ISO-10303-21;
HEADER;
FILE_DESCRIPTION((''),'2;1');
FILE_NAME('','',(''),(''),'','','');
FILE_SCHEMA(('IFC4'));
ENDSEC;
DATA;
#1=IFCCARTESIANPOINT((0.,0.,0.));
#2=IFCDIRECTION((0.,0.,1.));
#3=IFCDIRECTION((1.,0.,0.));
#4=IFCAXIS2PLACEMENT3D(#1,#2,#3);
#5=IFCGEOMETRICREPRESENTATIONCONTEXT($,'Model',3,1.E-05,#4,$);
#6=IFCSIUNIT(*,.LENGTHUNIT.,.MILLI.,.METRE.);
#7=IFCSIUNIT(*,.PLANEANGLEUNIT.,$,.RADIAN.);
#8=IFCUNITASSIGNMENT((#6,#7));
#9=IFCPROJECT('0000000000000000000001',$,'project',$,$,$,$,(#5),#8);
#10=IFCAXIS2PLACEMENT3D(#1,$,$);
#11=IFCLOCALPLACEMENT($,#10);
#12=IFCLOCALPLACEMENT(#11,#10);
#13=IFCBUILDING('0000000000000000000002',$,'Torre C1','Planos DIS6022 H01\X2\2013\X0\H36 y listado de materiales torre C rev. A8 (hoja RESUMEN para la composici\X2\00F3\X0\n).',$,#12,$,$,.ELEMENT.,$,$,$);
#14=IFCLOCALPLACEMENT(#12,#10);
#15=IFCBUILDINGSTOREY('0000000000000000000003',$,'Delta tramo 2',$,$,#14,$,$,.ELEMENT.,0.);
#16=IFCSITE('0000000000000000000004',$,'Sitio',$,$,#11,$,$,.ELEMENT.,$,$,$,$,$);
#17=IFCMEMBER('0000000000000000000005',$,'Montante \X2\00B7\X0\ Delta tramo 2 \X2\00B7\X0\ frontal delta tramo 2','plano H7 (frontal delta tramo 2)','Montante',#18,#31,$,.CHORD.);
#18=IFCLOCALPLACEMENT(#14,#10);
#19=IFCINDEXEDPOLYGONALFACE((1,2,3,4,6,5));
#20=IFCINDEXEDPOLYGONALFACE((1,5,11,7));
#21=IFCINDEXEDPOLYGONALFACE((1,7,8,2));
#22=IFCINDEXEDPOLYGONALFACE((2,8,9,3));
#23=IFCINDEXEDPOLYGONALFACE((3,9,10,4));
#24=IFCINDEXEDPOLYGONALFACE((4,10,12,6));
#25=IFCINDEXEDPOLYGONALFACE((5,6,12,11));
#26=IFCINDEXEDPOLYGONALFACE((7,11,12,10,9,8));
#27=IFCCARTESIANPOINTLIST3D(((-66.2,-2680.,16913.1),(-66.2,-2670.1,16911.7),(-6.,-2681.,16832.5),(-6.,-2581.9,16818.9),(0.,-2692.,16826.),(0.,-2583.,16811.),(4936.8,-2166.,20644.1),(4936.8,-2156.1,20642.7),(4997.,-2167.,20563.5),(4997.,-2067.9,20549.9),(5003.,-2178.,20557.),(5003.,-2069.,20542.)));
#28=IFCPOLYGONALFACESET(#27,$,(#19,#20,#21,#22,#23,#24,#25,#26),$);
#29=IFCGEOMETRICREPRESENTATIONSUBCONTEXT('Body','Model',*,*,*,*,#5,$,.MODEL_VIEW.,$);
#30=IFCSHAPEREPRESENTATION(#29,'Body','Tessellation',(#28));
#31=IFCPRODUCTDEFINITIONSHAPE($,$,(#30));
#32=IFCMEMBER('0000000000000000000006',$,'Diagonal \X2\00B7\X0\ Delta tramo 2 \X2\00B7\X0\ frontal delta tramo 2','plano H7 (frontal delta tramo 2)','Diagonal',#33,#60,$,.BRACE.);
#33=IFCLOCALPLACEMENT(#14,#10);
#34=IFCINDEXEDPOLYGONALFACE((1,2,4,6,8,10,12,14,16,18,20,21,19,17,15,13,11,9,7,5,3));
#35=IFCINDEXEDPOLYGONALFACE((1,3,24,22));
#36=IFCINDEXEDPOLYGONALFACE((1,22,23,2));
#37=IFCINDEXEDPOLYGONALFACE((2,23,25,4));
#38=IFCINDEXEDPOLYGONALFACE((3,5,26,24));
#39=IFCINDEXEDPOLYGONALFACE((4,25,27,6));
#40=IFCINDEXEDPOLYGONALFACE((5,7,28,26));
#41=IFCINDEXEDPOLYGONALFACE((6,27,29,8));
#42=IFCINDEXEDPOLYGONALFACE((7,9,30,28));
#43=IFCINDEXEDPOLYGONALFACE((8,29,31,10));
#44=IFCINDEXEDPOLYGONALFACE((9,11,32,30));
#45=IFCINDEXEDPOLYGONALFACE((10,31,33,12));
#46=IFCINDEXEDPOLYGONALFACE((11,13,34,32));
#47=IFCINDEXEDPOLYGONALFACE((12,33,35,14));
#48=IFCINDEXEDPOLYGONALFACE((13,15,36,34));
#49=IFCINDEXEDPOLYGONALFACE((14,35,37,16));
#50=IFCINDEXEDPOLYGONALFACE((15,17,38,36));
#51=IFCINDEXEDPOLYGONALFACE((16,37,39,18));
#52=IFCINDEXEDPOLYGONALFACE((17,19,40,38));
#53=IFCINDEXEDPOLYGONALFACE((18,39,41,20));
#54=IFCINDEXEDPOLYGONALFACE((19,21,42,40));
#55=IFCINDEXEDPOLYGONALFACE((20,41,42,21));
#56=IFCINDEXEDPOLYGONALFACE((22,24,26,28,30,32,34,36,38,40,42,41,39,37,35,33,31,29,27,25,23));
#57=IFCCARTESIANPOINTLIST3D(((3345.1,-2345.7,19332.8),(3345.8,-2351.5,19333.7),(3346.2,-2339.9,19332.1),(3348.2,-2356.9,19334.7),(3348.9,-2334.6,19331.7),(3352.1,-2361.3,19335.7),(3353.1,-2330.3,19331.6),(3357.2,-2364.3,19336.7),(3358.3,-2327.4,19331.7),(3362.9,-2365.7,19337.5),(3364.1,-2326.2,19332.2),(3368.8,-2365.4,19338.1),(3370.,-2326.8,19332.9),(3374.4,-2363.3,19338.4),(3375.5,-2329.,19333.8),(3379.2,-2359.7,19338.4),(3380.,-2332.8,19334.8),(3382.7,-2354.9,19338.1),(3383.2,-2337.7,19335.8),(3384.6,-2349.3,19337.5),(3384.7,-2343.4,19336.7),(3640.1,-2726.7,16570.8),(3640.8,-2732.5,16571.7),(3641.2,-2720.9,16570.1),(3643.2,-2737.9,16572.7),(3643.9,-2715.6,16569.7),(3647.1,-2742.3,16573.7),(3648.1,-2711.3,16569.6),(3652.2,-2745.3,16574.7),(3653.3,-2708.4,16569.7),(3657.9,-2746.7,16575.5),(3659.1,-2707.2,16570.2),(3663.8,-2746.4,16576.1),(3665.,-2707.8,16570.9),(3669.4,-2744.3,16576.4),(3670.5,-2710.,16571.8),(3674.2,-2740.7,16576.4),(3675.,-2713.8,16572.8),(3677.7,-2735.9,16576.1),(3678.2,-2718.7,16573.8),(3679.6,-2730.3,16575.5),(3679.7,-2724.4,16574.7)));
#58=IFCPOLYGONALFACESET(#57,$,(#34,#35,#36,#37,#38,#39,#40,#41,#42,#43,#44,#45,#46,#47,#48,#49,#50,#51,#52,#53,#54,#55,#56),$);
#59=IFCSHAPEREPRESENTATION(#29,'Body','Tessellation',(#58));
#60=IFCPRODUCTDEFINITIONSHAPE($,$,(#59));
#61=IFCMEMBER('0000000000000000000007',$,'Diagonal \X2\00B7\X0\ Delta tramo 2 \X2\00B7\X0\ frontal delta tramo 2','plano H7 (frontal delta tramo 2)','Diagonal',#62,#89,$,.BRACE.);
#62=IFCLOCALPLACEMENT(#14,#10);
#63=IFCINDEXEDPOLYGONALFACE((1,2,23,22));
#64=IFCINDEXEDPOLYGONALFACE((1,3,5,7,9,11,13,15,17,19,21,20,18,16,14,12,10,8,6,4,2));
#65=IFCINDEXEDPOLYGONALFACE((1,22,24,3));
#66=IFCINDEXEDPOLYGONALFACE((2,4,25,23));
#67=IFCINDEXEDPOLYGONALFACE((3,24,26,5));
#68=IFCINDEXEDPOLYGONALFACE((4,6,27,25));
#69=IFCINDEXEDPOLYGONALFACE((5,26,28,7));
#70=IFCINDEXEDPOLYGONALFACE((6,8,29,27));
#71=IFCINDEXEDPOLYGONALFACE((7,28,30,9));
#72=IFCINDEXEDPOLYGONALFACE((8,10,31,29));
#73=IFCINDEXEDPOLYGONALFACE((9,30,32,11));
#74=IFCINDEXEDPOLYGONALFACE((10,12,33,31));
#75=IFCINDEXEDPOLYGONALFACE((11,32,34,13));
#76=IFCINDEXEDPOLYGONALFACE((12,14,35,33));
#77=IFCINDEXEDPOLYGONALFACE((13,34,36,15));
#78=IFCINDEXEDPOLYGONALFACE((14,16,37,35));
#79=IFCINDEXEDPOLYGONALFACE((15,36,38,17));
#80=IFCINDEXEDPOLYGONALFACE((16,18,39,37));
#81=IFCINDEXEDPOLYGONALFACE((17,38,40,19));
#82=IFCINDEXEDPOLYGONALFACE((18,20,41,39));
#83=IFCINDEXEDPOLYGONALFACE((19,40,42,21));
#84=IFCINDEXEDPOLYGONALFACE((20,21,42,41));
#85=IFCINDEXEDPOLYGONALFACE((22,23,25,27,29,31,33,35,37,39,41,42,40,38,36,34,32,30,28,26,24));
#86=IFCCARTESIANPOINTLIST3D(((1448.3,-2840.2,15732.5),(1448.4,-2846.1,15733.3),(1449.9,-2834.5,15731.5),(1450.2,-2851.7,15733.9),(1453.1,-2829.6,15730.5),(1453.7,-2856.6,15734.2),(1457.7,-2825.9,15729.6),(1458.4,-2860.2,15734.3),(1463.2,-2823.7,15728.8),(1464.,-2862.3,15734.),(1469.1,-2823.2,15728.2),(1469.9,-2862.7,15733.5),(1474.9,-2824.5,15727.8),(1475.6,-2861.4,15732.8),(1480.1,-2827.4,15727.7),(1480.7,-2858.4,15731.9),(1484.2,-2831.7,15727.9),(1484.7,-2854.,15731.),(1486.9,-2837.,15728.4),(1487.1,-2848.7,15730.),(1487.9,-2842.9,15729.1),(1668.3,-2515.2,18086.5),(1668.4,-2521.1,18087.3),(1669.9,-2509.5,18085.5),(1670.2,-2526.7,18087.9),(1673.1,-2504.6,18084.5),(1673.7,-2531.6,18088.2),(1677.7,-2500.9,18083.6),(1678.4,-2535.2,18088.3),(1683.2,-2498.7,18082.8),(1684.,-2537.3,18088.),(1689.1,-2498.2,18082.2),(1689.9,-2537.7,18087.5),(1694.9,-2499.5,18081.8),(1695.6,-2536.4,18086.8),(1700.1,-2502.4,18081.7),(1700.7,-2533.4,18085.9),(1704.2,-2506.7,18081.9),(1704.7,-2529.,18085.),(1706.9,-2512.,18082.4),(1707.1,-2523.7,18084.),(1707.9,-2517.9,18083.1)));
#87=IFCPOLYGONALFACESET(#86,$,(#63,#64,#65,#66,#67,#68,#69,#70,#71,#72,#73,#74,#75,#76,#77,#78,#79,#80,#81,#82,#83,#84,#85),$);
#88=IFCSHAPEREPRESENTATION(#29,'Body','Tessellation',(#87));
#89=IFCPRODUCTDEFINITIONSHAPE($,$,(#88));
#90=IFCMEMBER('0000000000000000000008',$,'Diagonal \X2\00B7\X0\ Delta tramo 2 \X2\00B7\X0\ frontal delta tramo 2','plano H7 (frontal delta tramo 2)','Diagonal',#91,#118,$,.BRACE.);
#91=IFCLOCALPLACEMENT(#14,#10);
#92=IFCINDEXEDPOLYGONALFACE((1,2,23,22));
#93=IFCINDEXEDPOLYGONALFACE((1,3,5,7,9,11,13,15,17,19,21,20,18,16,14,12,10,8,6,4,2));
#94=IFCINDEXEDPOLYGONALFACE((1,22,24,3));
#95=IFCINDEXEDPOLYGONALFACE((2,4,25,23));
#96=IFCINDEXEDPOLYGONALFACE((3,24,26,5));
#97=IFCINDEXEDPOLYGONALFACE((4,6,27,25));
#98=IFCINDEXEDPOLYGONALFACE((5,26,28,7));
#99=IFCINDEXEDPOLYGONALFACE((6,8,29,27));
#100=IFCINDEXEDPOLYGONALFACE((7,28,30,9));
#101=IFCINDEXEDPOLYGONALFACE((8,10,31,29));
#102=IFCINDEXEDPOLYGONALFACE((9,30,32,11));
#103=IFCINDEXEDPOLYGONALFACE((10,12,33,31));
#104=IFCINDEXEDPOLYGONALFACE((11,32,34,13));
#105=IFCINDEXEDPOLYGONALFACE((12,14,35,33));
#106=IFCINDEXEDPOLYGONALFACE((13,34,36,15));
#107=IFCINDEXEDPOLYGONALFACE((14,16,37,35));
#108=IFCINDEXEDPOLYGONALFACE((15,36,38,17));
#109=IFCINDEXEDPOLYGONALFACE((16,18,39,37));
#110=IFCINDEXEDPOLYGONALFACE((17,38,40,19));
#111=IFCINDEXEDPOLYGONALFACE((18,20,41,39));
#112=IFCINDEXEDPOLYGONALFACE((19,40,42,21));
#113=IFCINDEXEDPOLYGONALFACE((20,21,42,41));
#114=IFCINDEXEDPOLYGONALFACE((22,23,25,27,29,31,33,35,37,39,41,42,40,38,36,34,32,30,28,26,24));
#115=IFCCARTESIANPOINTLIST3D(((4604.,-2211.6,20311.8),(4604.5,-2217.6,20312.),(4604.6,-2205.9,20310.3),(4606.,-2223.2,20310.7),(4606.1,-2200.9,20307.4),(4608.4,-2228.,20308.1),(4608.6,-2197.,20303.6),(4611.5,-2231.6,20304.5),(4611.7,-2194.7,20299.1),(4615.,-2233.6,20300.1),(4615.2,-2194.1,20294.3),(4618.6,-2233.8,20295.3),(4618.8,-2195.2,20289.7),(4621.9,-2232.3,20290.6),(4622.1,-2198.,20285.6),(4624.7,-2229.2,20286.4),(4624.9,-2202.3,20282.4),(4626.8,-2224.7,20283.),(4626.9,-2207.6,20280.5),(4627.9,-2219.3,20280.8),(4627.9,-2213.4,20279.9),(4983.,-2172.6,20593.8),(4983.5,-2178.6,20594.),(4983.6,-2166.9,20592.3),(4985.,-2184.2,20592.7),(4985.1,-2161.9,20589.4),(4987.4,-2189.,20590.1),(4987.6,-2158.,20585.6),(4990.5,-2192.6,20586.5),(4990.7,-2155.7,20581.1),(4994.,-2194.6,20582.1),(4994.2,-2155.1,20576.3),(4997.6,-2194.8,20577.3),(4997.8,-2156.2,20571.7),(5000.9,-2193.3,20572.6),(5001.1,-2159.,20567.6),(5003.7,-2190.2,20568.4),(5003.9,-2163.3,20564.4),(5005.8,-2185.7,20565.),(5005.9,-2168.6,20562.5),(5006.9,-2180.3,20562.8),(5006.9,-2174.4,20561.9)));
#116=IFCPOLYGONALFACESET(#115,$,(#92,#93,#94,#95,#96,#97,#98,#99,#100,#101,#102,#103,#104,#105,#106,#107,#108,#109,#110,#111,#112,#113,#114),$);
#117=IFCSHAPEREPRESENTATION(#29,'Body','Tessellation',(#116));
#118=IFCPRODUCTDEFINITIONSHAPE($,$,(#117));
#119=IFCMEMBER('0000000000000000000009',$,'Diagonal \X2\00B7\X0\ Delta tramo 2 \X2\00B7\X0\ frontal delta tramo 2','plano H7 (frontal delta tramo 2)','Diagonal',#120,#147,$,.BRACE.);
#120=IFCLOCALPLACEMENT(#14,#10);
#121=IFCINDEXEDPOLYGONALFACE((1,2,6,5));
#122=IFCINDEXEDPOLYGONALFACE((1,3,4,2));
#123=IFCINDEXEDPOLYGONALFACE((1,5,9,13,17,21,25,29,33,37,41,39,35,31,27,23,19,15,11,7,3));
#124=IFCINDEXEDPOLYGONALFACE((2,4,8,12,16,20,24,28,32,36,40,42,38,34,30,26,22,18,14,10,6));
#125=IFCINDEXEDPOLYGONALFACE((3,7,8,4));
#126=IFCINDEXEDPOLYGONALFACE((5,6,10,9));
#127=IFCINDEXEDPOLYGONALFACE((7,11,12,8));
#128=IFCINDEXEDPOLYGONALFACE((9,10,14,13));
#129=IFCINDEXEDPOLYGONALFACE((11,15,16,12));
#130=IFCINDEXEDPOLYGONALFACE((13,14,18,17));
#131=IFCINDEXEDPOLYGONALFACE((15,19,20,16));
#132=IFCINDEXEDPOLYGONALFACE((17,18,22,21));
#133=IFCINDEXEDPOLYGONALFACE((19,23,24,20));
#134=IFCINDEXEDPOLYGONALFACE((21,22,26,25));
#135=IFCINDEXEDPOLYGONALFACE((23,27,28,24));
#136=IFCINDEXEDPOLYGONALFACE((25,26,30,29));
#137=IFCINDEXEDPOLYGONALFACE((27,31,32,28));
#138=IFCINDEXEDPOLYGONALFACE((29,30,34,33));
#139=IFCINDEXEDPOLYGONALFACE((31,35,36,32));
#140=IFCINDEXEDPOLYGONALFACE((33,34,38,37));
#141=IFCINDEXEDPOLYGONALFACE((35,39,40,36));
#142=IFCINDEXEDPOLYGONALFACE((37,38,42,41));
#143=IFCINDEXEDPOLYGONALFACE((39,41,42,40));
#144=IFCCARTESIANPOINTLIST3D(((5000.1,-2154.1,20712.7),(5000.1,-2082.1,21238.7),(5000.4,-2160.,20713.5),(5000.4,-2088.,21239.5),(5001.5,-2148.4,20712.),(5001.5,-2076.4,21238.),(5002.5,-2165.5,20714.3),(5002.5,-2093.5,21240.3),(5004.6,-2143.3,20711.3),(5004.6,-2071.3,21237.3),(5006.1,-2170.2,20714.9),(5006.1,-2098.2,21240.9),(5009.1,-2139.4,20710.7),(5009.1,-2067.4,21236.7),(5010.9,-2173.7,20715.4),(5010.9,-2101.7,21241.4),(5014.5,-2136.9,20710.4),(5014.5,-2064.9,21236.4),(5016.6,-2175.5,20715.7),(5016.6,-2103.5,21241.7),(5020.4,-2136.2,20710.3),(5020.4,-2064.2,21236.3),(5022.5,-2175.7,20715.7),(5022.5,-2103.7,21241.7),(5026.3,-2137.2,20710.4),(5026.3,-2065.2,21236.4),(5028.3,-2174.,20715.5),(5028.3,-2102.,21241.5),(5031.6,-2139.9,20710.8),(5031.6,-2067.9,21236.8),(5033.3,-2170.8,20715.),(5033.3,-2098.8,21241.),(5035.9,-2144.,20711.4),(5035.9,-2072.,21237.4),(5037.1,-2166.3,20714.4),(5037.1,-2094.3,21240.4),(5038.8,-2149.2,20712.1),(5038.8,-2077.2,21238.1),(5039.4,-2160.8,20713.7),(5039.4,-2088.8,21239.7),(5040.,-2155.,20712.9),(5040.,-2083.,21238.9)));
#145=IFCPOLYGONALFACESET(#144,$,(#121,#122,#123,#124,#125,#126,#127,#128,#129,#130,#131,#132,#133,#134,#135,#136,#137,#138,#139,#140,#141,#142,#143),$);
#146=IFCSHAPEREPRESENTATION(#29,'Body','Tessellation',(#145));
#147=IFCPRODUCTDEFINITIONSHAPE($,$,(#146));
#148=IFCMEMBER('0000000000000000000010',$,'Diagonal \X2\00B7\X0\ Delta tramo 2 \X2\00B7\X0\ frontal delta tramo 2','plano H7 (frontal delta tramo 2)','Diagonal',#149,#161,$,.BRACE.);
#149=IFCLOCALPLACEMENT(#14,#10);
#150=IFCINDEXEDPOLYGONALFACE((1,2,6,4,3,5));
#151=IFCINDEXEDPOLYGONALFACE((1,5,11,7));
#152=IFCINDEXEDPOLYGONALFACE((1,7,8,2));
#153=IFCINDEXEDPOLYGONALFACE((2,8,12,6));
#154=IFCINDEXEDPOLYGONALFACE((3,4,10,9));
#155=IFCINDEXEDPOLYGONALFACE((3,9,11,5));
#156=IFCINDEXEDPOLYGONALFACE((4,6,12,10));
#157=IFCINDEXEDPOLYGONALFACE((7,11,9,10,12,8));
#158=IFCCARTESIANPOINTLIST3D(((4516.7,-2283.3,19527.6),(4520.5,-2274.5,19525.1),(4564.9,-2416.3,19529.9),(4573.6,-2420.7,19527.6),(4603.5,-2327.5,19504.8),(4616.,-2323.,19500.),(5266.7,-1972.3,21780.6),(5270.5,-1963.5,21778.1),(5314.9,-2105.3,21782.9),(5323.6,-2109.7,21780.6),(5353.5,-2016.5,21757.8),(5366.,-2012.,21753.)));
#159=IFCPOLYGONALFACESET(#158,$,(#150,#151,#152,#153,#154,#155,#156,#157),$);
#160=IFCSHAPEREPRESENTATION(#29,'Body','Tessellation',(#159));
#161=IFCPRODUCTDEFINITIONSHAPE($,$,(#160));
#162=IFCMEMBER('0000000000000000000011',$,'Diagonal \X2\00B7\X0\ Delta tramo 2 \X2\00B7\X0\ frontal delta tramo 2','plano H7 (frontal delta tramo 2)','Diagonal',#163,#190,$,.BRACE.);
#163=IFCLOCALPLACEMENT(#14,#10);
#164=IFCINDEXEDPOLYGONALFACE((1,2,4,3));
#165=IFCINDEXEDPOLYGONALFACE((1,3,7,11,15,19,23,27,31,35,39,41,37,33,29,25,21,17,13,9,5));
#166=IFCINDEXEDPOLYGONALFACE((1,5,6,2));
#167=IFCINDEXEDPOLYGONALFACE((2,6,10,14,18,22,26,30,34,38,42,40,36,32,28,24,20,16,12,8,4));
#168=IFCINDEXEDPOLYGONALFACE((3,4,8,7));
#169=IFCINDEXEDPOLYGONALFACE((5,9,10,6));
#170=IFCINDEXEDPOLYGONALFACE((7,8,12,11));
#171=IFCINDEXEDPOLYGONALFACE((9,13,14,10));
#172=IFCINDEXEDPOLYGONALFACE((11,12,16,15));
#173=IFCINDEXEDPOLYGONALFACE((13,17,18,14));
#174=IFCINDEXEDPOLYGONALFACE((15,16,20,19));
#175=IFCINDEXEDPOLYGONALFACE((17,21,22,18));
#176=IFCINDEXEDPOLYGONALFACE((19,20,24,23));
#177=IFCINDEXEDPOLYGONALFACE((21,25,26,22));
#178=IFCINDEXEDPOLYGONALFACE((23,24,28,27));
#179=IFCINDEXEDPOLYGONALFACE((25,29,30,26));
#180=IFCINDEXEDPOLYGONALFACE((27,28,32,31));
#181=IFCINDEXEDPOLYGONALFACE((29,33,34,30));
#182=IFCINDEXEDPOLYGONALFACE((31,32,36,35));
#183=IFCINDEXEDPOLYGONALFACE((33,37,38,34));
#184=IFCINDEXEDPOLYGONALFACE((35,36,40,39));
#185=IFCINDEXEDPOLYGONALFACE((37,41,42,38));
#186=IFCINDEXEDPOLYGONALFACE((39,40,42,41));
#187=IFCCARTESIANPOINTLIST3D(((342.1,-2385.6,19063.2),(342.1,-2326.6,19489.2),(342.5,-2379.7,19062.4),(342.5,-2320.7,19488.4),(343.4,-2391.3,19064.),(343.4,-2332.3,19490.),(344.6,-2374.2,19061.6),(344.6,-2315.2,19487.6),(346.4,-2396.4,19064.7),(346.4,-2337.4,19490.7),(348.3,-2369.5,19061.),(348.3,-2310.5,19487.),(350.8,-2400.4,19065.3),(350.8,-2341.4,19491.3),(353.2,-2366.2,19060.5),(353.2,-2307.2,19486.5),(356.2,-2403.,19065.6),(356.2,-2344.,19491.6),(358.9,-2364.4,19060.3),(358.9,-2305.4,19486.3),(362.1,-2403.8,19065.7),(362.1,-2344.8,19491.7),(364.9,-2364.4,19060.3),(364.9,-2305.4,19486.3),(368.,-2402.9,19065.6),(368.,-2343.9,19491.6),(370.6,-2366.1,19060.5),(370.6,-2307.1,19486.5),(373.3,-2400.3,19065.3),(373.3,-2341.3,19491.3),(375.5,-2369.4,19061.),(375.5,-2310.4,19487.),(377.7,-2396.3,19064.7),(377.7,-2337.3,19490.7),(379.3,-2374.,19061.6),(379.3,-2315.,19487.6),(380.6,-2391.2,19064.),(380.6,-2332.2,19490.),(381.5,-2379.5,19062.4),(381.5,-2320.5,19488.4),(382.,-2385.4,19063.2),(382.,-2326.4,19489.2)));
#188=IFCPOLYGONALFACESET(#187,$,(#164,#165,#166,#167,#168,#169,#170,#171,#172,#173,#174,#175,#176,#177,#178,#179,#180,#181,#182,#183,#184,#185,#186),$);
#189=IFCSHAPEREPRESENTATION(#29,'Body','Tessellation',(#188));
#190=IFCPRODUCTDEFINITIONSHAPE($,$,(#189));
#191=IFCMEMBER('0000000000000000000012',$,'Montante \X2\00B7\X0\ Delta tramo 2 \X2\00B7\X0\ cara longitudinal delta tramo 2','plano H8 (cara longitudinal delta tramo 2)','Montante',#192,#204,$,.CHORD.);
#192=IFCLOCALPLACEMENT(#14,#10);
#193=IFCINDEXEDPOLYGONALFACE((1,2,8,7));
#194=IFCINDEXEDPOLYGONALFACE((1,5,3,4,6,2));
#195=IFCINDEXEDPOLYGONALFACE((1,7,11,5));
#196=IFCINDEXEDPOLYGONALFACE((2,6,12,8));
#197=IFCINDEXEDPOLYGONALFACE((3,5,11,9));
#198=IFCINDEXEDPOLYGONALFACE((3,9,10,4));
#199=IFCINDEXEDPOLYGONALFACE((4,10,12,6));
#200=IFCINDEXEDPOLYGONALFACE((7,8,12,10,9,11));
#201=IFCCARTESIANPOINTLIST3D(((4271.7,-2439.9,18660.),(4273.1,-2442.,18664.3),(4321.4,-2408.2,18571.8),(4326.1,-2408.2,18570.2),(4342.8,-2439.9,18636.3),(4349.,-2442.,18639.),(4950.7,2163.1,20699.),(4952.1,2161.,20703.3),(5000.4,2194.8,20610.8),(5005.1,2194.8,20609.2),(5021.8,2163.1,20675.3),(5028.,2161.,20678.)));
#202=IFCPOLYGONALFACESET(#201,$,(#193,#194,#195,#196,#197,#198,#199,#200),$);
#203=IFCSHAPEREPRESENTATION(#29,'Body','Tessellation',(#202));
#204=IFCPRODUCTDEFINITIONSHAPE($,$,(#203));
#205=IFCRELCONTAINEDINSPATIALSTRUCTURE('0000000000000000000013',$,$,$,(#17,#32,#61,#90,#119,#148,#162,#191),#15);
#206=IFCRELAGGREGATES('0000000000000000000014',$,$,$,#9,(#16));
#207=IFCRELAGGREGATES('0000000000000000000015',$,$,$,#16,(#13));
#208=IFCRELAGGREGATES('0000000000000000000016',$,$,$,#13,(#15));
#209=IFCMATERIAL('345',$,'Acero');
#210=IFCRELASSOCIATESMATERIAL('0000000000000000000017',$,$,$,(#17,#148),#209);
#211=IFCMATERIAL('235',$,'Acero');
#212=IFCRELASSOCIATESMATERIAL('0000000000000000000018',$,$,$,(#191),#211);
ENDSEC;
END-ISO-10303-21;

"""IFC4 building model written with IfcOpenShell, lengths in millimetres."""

from ifc_helpers import new_model, si_unit, frame, frame_2d, origin, origin_with_axes, place, context, subcontext, project, spatial, circle, l_section, extrude, material, element, save


model = new_model("IFC4")

# Units and contexts
model_context = context("Model", 3, precision=1e-05, world=origin_with_axes())
body_context = subcontext(model_context, "Body", "Model", "MODEL_VIEW")
ifc_project = project(units=[si_unit("LENGTHUNIT", "METRE", prefix="MILLI"), si_unit("PLANEANGLEUNIT", "RADIAN")], contexts=[model_context])

# Site, building, storey
site_placement = place(None, origin())
site = spatial("IfcSite", under=ifc_project, at=site_placement, Name="Sitio", CompositionType="ELEMENT")
building_placement = place(site_placement, origin())
building = spatial("IfcBuilding", under=site, at=building_placement, Name="Torre C1", Description="Planos DIS6022 H01–H36 y listado de materiales torre C rev. A8 (hoja RESUMEN para la composición).", CompositionType="ELEMENT")
storey_placement = place(building_placement, origin())
storey = spatial("IfcBuildingStorey", under=building, at=storey_placement, Name="Delta tramo 2", CompositionType="ELEMENT", Elevation=0.0)

# Members
ifc_material_1 = material(Name="345", Category="Acero")
member_1_placement = place(storey_placement, frame((5003.0, -2178.0, 20557.0), z_axis=(-0.798926, -0.08208, -0.595801), x_axis=(-0.601429, 0.109034, 0.791451)))
element("IfcMember", 1, at=member_1_placement, inside=storey, material=ifc_material_1, Name="Montante · Delta tramo 2 · frontal delta tramo 2", Description="plano H7 (frontal delta tramo 2)", ObjectType="Montante", PredefinedType="CHORD", context=body_context, shape_type="SweptSolid", body=[
    extrude(l_section(Depth=110.0, Width=110.0, Thickness=10.0, at=frame_2d((55.0, 55.0))), None, (0.0, 0.0, 1.0), 6262.2),
])
member_2_placement = place(storey_placement, frame((3365.0, -2346.0, 19335.0), z_axis=(0.105217, -0.135891, -0.985121), x_axis=(-0.804373, 0.570852, -0.164658)))
element("IfcMember", 2, at=member_2_placement, inside=storey, Name="Diagonal · Delta tramo 2 · frontal delta tramo 2", Description="plano H7 (frontal delta tramo 2)", ObjectType="Diagonal", PredefinedType="BRACE", context=body_context, shape_type="SweptSolid", body=[
    extrude(circle(Radius=20.0), None, (0.0, 0.0, 1.0), 2803.7),
])
member_3_placement = place(storey_placement, frame((1688.0, -2518.0, 18085.0), z_axis=(-0.092186, -0.136183, -0.986385), x_axis=(-0.515108, 0.854278, -0.069803)))
element("IfcMember", 3, at=member_3_placement, inside=storey, Name="Diagonal · Delta tramo 2 · frontal delta tramo 2", Description="plano H7 (frontal delta tramo 2)", ObjectType="Diagonal", PredefinedType="BRACE", context=body_context, shape_type="SweptSolid", body=[
    extrude(circle(Radius=20.0), None, (0.0, 0.0, 1.0), 2386.5),
])
member_4_placement = place(storey_placement, frame((4995.0, -2175.0, 20578.0), z_axis=(-0.79956, -0.082277, -0.594923), x_axis=(-0.493108, 0.655414, 0.572081)))
element("IfcMember", 4, at=member_4_placement, inside=storey, Name="Diagonal · Delta tramo 2 · frontal delta tramo 2", Description="plano H7 (frontal delta tramo 2)", ObjectType="Diagonal", PredefinedType="BRACE", context=body_context, shape_type="SweptSolid", body=[
    extrude(circle(Radius=20.0), None, (0.0, 0.0, 1.0), 474.0),
])
member_5_placement = place(storey_placement, frame((5020.0, -2156.0, 20713.0), z_axis=(0.0, 0.135618, 0.990761), x_axis=(-0.922505, 0.382419, -0.052346)))
element("IfcMember", 5, at=member_5_placement, inside=storey, Name="Diagonal · Delta tramo 2 · frontal delta tramo 2", Description="plano H7 (frontal delta tramo 2)", ObjectType="Diagonal", PredefinedType="BRACE", context=body_context, shape_type="SweptSolid", body=[
    extrude(circle(Radius=20.0), None, (0.0, 0.0, 1.0), 530.9),
])
member_6_placement = place(storey_placement, frame((4616.0, -2323.0, 19500.0), z_axis=(0.313174, 0.129863, 0.940775), x_axis=(-0.867893, 0.441341, 0.22799)))
element("IfcMember", 6, at=member_6_placement, inside=storey, material=ifc_material_1, Name="Diagonal · Delta tramo 2 · frontal delta tramo 2", Description="plano H7 (frontal delta tramo 2)", ObjectType="Diagonal", PredefinedType="BRACE", context=body_context, shape_type="SweptSolid", body=[
    extrude(l_section(Depth=110.0, Width=110.0, Thickness=10.0, at=frame_2d((55.0, 55.0))), None, (0.0, 0.0, 1.0), 2394.8),
])
for number, where, z_axis, x_axis, name in (
    (7, (362.0, -2384.0, 19063.0), (0.0, 0.137188, 0.990545), (-0.153379, 0.978824, -0.135565), "Diagonal · Delta tramo 2 · frontal delta tramo 2"),
):
    element("IfcMember", number, at=place(storey_placement, frame(where, z_axis=z_axis, x_axis=x_axis)), inside=storey, Name=name, Description="plano H7 (frontal delta tramo 2)", ObjectType="Diagonal", PredefinedType="BRACE", context=body_context, shape_type="SweptSolid", body=[
        extrude(circle(Radius=20.0), None, (0.0, 0.0, 1.0), 430.1),
    ])
ifc_material_2 = material(Name="235", Category="Acero")
member_7_placement = place(storey_placement, frame((4349.0, -2442.0, 18639.0), z_axis=(0.133662, 0.906106, 0.40138), x_axis=(-0.286283, 0.42305, -0.859692)))
element("IfcMember", 8, at=member_7_placement, inside=storey, material=ifc_material_2, Name="Montante · Delta tramo 2 · cara longitudinal delta tramo 2", Description="plano H8 (cara longitudinal delta tramo 2)", ObjectType="Montante", PredefinedType="CHORD", context=body_context, shape_type="SweptSolid", body=[
    extrude(l_section(Depth=80.0, Width=80.0, Thickness=5.0, at=frame_2d((40.0, 40.0))), None, (0.0, 0.0, 1.0), 5080.0),
])

save(model, "model.ifc")
